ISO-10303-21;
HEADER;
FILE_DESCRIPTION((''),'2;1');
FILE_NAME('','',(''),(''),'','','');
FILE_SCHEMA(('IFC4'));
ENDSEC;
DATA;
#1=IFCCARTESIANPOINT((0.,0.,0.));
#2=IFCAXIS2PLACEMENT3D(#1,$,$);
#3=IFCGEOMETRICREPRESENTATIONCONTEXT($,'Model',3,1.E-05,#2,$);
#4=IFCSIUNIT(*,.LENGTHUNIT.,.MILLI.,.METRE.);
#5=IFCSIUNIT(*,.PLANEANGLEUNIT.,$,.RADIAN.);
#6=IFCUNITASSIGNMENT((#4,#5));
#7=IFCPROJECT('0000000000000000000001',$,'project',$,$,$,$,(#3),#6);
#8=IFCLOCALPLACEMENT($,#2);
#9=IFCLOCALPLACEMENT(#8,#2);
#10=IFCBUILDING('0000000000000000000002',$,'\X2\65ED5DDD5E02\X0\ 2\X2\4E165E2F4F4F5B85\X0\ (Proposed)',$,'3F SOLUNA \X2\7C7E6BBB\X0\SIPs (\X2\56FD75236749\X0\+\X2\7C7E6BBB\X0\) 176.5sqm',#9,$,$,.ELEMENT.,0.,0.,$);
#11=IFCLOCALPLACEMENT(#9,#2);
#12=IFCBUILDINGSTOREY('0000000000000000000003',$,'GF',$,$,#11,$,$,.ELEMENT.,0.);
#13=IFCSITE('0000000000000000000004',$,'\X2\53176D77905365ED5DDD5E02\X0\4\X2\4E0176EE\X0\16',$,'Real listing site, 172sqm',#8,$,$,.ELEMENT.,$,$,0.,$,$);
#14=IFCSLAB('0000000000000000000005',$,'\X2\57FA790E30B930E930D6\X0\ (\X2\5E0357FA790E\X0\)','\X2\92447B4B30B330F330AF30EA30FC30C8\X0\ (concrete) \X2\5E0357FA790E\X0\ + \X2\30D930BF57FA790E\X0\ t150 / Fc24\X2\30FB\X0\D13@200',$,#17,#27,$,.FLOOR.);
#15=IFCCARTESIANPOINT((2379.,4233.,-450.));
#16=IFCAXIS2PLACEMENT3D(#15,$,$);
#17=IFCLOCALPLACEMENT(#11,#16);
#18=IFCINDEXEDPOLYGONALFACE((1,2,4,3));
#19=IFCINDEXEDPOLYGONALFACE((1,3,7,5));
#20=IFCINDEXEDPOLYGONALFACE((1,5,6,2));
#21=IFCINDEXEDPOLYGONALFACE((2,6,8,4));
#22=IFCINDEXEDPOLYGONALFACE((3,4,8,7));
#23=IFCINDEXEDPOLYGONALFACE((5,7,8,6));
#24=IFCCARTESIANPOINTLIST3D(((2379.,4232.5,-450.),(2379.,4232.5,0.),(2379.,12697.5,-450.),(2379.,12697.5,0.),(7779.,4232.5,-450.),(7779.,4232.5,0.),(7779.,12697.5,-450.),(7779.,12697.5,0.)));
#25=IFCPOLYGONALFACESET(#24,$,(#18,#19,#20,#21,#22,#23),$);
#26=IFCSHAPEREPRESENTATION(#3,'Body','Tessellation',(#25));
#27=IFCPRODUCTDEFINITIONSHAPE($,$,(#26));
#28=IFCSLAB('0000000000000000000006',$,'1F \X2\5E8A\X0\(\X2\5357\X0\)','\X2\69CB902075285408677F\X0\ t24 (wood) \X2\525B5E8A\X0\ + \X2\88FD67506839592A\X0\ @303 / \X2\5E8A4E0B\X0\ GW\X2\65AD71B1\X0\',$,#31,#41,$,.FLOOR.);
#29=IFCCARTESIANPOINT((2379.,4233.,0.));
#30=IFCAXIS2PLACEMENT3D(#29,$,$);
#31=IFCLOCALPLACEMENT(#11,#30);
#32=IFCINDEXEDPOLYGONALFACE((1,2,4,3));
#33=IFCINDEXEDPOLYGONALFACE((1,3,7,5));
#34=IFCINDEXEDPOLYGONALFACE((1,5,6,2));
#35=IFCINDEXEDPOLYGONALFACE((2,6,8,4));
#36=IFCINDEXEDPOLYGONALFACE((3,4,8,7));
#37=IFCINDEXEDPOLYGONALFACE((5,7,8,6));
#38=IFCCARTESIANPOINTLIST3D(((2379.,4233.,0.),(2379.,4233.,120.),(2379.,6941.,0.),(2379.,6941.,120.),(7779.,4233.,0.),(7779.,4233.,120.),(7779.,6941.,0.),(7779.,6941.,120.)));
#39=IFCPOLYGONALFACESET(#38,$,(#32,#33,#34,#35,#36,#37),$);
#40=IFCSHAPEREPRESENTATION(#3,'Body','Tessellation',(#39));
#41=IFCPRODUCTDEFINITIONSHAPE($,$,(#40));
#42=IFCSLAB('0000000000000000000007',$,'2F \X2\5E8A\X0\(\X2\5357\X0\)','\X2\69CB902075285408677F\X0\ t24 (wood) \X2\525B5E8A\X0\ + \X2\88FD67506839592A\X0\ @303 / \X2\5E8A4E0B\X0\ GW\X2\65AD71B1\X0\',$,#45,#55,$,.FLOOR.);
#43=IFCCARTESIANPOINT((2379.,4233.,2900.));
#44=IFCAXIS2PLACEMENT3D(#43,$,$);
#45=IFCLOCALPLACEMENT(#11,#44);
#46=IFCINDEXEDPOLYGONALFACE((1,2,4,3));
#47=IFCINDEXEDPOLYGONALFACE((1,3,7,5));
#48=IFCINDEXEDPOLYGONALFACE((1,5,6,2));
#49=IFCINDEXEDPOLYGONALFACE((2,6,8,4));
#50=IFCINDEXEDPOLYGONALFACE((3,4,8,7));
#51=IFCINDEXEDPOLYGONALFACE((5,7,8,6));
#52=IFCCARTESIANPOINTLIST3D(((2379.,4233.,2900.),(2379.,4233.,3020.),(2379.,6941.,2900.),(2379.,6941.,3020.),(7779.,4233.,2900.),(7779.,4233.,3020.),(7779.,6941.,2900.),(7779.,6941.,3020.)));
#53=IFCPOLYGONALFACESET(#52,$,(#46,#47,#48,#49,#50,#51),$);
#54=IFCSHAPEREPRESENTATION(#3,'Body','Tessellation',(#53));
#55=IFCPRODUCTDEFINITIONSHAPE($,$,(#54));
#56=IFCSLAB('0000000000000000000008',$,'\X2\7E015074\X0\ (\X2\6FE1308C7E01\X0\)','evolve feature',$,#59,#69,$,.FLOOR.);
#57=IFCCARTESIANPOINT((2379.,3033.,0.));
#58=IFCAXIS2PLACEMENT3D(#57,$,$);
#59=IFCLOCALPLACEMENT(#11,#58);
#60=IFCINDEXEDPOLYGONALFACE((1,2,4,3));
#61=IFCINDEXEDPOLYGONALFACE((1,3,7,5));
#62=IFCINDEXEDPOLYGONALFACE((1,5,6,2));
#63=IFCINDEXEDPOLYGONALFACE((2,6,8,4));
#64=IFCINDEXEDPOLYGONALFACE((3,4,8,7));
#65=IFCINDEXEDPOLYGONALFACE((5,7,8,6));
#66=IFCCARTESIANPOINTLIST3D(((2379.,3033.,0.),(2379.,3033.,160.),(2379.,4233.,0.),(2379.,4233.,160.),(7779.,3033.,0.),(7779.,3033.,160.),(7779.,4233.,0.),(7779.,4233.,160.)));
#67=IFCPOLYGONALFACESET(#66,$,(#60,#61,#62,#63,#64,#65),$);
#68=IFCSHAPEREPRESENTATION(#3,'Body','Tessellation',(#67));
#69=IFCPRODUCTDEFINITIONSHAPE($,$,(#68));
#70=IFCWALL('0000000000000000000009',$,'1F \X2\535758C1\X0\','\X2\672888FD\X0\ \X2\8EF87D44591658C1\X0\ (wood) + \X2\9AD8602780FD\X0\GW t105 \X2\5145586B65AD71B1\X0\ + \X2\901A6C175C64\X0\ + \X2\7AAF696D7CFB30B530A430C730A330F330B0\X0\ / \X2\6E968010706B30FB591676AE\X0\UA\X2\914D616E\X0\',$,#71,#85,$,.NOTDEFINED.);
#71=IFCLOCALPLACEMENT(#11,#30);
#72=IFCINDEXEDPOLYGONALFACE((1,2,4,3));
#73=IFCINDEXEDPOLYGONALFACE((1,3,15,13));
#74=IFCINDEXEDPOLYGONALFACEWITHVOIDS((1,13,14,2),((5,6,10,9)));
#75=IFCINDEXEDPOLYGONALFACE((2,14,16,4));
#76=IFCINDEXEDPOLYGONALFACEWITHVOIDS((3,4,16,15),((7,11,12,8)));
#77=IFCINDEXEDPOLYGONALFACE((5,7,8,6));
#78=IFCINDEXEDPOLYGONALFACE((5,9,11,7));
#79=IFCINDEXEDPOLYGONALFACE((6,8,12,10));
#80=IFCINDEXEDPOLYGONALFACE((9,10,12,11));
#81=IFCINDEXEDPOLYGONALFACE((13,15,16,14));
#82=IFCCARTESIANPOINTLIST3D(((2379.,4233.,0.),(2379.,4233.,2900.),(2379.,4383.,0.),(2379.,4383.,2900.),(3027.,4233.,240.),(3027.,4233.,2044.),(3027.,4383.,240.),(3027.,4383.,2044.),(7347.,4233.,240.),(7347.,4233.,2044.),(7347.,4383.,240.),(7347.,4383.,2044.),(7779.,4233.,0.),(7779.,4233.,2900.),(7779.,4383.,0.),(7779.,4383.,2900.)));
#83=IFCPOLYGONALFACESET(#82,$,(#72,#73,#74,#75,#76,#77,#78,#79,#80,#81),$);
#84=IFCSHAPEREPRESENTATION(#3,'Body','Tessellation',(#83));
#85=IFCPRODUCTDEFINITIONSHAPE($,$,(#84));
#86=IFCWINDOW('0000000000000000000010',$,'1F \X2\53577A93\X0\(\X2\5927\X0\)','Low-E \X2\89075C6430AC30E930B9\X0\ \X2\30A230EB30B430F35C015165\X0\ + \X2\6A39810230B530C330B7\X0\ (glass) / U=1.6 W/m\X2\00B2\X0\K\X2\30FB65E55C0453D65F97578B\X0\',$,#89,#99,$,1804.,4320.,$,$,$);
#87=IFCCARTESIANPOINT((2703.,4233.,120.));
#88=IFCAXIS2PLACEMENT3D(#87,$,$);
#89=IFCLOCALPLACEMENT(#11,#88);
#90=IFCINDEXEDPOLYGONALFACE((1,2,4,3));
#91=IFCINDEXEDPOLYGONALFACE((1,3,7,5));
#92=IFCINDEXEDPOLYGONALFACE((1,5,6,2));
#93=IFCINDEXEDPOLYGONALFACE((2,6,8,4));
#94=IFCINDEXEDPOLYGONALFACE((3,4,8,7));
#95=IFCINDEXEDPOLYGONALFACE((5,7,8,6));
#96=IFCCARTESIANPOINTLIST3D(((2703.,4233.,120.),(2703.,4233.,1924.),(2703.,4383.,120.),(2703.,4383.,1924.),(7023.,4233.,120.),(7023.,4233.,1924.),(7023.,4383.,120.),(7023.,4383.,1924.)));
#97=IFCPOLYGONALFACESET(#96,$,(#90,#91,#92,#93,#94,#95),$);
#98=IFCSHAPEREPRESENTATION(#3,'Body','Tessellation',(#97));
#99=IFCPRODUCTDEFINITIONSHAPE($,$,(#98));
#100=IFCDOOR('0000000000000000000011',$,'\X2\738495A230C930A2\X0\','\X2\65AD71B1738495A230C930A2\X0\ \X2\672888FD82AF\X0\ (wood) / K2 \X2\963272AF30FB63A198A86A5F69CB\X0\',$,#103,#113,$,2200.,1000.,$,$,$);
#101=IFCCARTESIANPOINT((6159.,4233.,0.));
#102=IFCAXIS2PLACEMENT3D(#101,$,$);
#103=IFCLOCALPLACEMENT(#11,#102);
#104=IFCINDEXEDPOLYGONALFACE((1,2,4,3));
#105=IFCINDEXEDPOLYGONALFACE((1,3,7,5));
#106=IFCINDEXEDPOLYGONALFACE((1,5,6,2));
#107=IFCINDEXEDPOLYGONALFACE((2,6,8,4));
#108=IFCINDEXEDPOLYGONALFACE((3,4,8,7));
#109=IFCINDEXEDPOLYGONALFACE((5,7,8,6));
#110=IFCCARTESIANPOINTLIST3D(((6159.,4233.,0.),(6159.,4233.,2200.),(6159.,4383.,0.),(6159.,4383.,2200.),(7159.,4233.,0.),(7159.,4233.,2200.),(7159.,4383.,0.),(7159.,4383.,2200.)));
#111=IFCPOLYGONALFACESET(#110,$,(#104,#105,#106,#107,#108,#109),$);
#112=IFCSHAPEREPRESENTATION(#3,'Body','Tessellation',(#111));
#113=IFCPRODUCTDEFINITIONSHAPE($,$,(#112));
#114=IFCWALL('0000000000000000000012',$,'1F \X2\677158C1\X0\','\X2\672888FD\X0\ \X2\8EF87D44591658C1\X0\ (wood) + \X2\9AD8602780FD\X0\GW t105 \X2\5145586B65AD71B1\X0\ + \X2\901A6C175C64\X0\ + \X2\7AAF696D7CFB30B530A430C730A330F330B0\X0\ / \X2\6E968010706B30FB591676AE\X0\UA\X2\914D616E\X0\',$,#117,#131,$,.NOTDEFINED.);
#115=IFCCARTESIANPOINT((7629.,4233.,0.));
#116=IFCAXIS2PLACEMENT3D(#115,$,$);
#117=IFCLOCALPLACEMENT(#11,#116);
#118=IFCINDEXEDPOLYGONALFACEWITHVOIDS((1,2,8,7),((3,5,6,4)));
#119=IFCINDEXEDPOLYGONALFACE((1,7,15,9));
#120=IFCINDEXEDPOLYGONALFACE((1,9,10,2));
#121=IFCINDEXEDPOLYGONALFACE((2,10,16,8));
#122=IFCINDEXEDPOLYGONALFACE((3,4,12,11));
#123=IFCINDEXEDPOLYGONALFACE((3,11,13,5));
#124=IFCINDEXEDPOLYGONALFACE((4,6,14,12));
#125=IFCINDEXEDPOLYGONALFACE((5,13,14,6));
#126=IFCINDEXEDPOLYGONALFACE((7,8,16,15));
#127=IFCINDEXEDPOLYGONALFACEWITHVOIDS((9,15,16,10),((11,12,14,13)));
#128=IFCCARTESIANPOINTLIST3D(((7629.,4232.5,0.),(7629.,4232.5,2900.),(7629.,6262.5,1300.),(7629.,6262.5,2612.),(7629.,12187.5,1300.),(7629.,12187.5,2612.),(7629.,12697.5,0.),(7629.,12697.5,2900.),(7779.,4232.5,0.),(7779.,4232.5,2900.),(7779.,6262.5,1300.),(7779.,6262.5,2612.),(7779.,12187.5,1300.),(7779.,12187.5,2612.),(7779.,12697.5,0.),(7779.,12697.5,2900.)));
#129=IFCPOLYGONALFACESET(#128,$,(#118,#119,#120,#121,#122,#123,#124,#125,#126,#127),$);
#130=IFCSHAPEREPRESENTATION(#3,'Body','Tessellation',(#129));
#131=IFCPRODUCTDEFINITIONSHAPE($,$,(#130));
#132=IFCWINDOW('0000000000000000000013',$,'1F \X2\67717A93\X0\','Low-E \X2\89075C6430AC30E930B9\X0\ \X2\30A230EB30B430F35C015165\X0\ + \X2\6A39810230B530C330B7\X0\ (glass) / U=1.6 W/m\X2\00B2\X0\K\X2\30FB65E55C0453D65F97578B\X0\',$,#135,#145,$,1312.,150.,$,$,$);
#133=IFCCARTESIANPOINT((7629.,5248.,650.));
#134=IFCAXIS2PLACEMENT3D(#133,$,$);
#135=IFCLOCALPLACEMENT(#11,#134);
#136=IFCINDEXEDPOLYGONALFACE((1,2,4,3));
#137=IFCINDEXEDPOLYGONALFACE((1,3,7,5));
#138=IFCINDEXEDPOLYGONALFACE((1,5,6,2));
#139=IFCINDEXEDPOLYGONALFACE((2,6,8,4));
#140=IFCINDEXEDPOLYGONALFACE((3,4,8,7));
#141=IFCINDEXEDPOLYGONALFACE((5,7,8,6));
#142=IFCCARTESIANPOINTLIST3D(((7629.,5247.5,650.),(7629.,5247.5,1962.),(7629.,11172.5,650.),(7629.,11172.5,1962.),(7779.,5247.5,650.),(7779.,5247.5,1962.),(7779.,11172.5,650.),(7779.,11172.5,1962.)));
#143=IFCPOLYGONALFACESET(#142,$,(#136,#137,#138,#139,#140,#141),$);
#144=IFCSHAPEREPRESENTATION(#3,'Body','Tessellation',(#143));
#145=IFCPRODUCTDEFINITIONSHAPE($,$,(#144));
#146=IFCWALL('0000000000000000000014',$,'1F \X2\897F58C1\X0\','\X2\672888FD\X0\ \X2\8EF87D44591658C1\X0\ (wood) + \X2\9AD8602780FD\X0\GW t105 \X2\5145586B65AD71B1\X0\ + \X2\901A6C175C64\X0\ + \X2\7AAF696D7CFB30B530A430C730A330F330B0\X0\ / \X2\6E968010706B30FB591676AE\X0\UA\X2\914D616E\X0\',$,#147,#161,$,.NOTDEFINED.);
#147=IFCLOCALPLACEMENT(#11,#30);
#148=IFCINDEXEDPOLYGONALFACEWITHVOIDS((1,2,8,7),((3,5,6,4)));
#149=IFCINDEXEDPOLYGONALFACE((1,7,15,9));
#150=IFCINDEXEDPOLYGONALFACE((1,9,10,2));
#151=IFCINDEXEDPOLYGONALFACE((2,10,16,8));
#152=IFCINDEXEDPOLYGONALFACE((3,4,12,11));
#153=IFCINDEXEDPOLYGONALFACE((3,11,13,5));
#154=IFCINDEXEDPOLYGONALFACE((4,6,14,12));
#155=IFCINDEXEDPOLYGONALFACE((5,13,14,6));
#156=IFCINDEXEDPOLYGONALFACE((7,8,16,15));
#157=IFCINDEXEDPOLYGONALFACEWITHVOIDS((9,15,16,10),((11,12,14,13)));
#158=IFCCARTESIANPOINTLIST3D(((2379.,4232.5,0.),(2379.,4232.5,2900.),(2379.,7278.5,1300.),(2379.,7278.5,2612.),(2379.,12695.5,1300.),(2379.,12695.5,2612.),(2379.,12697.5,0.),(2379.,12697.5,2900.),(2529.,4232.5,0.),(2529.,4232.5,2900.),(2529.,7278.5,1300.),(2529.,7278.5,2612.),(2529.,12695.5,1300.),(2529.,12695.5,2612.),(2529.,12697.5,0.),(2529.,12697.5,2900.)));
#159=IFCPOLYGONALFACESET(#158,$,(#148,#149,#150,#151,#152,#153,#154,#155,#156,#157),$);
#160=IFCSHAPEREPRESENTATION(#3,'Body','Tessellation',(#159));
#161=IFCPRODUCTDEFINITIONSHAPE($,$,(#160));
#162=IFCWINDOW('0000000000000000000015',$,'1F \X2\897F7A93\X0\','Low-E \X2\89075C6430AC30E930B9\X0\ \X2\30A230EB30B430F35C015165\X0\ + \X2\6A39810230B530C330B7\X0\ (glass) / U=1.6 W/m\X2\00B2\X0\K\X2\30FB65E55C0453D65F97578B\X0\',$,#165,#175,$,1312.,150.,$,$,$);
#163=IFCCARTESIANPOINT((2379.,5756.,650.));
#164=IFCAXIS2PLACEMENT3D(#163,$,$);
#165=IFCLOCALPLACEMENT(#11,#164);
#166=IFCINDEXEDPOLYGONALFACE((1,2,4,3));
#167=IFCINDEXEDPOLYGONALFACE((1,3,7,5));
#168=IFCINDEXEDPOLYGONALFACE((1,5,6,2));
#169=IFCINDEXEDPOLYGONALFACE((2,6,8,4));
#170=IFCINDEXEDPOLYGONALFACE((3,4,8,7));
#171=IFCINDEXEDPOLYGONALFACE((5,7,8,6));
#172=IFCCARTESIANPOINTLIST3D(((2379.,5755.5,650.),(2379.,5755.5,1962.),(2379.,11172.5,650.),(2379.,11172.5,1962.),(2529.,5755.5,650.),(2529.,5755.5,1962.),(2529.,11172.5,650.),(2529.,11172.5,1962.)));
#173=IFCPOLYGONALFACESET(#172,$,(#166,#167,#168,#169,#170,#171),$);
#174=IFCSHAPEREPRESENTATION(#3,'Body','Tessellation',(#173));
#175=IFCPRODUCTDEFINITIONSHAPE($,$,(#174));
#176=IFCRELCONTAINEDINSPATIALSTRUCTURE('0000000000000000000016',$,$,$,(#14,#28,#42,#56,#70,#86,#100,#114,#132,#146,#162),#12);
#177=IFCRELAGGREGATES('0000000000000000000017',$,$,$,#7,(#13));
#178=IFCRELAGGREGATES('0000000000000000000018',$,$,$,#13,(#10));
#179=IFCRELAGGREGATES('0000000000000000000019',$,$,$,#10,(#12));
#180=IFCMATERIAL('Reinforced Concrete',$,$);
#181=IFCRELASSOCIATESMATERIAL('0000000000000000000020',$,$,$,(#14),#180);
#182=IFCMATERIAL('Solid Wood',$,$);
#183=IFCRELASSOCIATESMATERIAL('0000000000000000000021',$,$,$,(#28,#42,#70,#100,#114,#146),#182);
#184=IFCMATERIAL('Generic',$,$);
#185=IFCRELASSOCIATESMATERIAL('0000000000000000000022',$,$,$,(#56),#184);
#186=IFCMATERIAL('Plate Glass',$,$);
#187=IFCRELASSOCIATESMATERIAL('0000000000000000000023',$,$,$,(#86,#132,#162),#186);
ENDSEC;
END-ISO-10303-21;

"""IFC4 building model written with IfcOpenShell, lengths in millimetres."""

from ifc_helpers import new_model, si_unit, frame, frame_2d, origin, place, context, project, spatial, rectangle, extrude, material, element, fill, save


model = new_model("IFC4")

# Units and contexts
model_context = context("Model", 3, precision=1e-05, world=origin())
ifc_project = project(units=[si_unit("LENGTHUNIT", "METRE", prefix="MILLI"), si_unit("PLANEANGLEUNIT", "RADIAN")], contexts=[model_context])

# Site, building, storey
site_placement = place(None, origin())
site = spatial("IfcSite", under=ifc_project, at=site_placement, Name="北海道旭川市4丁目16", ObjectType="Real listing site, 172sqm", CompositionType="ELEMENT", RefElevation=0.0)
building_placement = place(site_placement, origin())
building = spatial("IfcBuilding", under=site, at=building_placement, Name="旭川市 2世帯住宅 (Proposed)", ObjectType="3F SOLUNA 籾殻SIPs (国産杉+籾殻) 176.5sqm", CompositionType="ELEMENT", ElevationOfRefHeight=0.0, ElevationOfTerrain=0.0)
storey_placement = place(building_placement, origin())
storey = spatial("IfcBuildingStorey", under=building, at=storey_placement, Name="GF", CompositionType="ELEMENT", Elevation=0.0)

# Slabs
ifc_material_1 = material(Name="Reinforced Concrete")
slab_1_placement = place(storey_placement, frame((2379.0, 4233.0, -450.0)))
element("IfcSlab", 1, at=slab_1_placement, inside=storey, material=ifc_material_1, Name="基礎スラブ (布基礎)", Description="鉄筋コンクリート (concrete) 布基礎 + ベタ基礎 t150 / Fc24・D13@200", PredefinedType="FLOOR", context=model_context, shape_type="SweptSolid", body=[
    extrude(rectangle(XDim=5400.0, YDim=8465.0, at=frame_2d((2700.0, 4232.0))), frame((2379.0, 4233.0, -450.0)), (0.0, 0.0, 1.0), 450.0),
])
ifc_material_2 = material(Name="Solid Wood")
slab_2_placement = place(storey_placement, frame((2379.0, 4233.0, 0.0)))
element("IfcSlab", 2, at=slab_2_placement, inside=storey, material=ifc_material_2, Name="1F 床(南)", Description="構造用合板 t24 (wood) 剛床 + 製材根太 @303 / 床下 GW断熱", PredefinedType="FLOOR", context=model_context, shape_type="SweptSolid", body=[
    extrude(rectangle(XDim=5400.0, YDim=2708.0, at=frame_2d((2700.0, 1354.0))), frame((2379.0, 4233.0, 0.0)), (0.0, 0.0, 1.0), 120.0),
])
slab_3_placement = place(storey_placement, frame((2379.0, 4233.0, 2900.0)))
element("IfcSlab", 3, at=slab_3_placement, inside=storey, material=ifc_material_2, Name="2F 床(南)", Description="構造用合板 t24 (wood) 剛床 + 製材根太 @303 / 床下 GW断熱", PredefinedType="FLOOR", context=model_context, shape_type="SweptSolid", body=[
    extrude(rectangle(XDim=5400.0, YDim=2708.0, at=frame_2d((2700.0, 1354.0))), frame((2379.0, 4233.0, 2900.0)), (0.0, 0.0, 1.0), 120.0),
])
ifc_material_3 = material(Name="Generic")
slab_4_placement = place(storey_placement, frame((2379.0, 3033.0, 0.0)))
element("IfcSlab", 4, at=slab_4_placement, inside=storey, material=ifc_material_3, Name="縁側 (濡れ縁)", Description="evolve feature", PredefinedType="FLOOR", context=model_context, shape_type="SweptSolid", body=[
    extrude(rectangle(XDim=5400.0, YDim=1200.0, at=frame_2d((2700.0, 600.0))), frame((2379.0, 3033.0, 0.0)), (0.0, 0.0, 1.0), 160.0),
])

# Wall, openings, window, door
wall_1_placement = place(storey_placement, frame((2379.0, 4233.0, 0.0)))
wall_1 = element("IfcWall", 5, at=wall_1_placement, inside=storey, material=ifc_material_2, Name="1F 南壁", Description="木製 軸組外壁 (wood) + 高性能GW t105 充填断熱 + 通気層 + 窯業系サイディング / 準耐火・外皮UA配慮", PredefinedType="NOTDEFINED", context=model_context, shape_type="SweptSolid", body=[
    extrude(rectangle(XDim=5400.0, YDim=150.0, at=frame_2d((2700.0, 75.0))), frame((2379.0, 4233.0, 0.0)), (0.0, 0.0, 1.0), 2900.0),
])
opening_1_placement = place(storey_placement, frame((2703.0, 4233.0, 120.0)))
opening_1 = element("IfcOpeningElement", 6, at=opening_1_placement, cuts=wall_1, PredefinedType="NOTDEFINED", context=model_context, shape_type="SweptSolid", body=[
    extrude(rectangle(XDim=4320.0, YDim=150.0, at=frame_2d((2160.0, 75.0))), frame((2703.0, 4233.0, 120.0)), (0.0, 0.0, 1.0), 1804.0),
])
opening_2_placement = place(storey_placement, frame((6159.0, 4233.0, 0.0)))
opening_2 = element("IfcOpeningElement", 7, at=opening_2_placement, cuts=wall_1, PredefinedType="NOTDEFINED", context=model_context, shape_type="SweptSolid", body=[
    extrude(rectangle(XDim=1000.0, YDim=150.0, at=frame_2d((500.0, 75.0))), frame((6159.0, 4233.0, 0.0)), (0.0, 0.0, 1.0), 2200.0),
])
ifc_material_4 = material(Name="Plate Glass")
window_1_placement = place(storey_placement, frame((2703.0, 4233.0, 120.0)))
window_1 = element("IfcWindow", 8, at=window_1_placement, inside=storey, material=ifc_material_4, Name="1F 南窓(大)", Description="Low-E 複層ガラス アルゴン封入 + 樹脂サッシ (glass) / U=1.6 W/m²K・日射取得型", OverallHeight=1804.0, OverallWidth=4320.0, context=model_context, shape_type="SweptSolid", body=[
    extrude(rectangle(XDim=4320.0, YDim=150.0, at=frame_2d((2160.0, 75.0))), frame((2703.0, 4233.0, 120.0)), (0.0, 0.0, 1.0), 1804.0),
])
fill(opening_1, window_1)
door_placement = place(storey_placement, frame((6159.0, 4233.0, 0.0)))
door = element("IfcDoor", 9, at=door_placement, inside=storey, material=ifc_material_2, Name="玄関ドア", Description="断熱玄関ドア 木製芯 (wood) / K2 防犯・採風機構", OverallHeight=2200.0, OverallWidth=1000.0, context=model_context, shape_type="SweptSolid", body=[
    extrude(rectangle(XDim=1000.0, YDim=150.0, at=frame_2d((500.0, 75.0))), frame((6159.0, 4233.0, 0.0)), (0.0, 0.0, 1.0), 2200.0),
])
fill(opening_2, door)

# Walls, openings, windows
wall_2_placement = place(storey_placement, frame((7629.0, 4233.0, 0.0)))
wall_2 = element("IfcWall", 10, at=wall_2_placement, inside=storey, material=ifc_material_2, Name="1F 東壁", Description="木製 軸組外壁 (wood) + 高性能GW t105 充填断熱 + 通気層 + 窯業系サイディング / 準耐火・外皮UA配慮", PredefinedType="NOTDEFINED", context=model_context, shape_type="SweptSolid", body=[
    extrude(rectangle(XDim=150.0, YDim=8465.0, at=frame_2d((75.0, 4232.0))), frame((7629.0, 4233.0, 0.0)), (0.0, 0.0, 1.0), 2900.0),
])
opening_3_placement = place(storey_placement, frame((7629.0, 5248.0, 650.0)))
opening_3 = element("IfcOpeningElement", 11, at=opening_3_placement, cuts=wall_2, PredefinedType="NOTDEFINED", context=model_context, shape_type="SweptSolid", body=[
    extrude(rectangle(XDim=150.0, YDim=5925.0, at=frame_2d((75.0, 2962.0))), frame((7629.0, 5248.0, 650.0)), (0.0, 0.0, 1.0), 1312.0),
])
window_2_placement = place(storey_placement, frame((7629.0, 5248.0, 650.0)))
window_2 = element("IfcWindow", 12, at=window_2_placement, inside=storey, material=ifc_material_4, Name="1F 東窓", Description="Low-E 複層ガラス アルゴン封入 + 樹脂サッシ (glass) / U=1.6 W/m²K・日射取得型", OverallHeight=1312.0, OverallWidth=150.0, context=model_context, shape_type="SweptSolid", body=[
    extrude(rectangle(XDim=150.0, YDim=5925.0, at=frame_2d((75.0, 2962.0))), frame((7629.0, 5248.0, 650.0)), (0.0, 0.0, 1.0), 1312.0),
])
fill(opening_3, window_2)
wall_3_placement = place(storey_placement, frame((2379.0, 4233.0, 0.0)))
wall_3 = element("IfcWall", 13, at=wall_3_placement, inside=storey, material=ifc_material_2, Name="1F 西壁", Description="木製 軸組外壁 (wood) + 高性能GW t105 充填断熱 + 通気層 + 窯業系サイディング / 準耐火・外皮UA配慮", PredefinedType="NOTDEFINED", context=model_context, shape_type="SweptSolid", body=[
    extrude(rectangle(XDim=150.0, YDim=8465.0, at=frame_2d((75.0, 4232.0))), frame((2379.0, 4233.0, 0.0)), (0.0, 0.0, 1.0), 2900.0),
])
opening_4_placement = place(storey_placement, frame((2379.0, 5756.0, 650.0)))
opening_4 = element("IfcOpeningElement", 14, at=opening_4_placement, cuts=wall_3, PredefinedType="NOTDEFINED", context=model_context, shape_type="SweptSolid", body=[
    extrude(rectangle(XDim=150.0, YDim=5417.0, at=frame_2d((75.0, 2708.0))), frame((2379.0, 5756.0, 650.0)), (0.0, 0.0, 1.0), 1312.0),
])
window_3_placement = place(storey_placement, frame((2379.0, 5756.0, 650.0)))
window_3 = element("IfcWindow", 15, at=window_3_placement, inside=storey, material=ifc_material_4, Name="1F 西窓", Description="Low-E 複層ガラス アルゴン封入 + 樹脂サッシ (glass) / U=1.6 W/m²K・日射取得型", OverallHeight=1312.0, OverallWidth=150.0, context=model_context, shape_type="SweptSolid", body=[
    extrude(rectangle(XDim=150.0, YDim=5417.0, at=frame_2d((75.0, 2708.0))), frame((2379.0, 5756.0, 650.0)), (0.0, 0.0, 1.0), 1312.0),
])
fill(opening_4, window_3)

save(model, "model.ifc")
